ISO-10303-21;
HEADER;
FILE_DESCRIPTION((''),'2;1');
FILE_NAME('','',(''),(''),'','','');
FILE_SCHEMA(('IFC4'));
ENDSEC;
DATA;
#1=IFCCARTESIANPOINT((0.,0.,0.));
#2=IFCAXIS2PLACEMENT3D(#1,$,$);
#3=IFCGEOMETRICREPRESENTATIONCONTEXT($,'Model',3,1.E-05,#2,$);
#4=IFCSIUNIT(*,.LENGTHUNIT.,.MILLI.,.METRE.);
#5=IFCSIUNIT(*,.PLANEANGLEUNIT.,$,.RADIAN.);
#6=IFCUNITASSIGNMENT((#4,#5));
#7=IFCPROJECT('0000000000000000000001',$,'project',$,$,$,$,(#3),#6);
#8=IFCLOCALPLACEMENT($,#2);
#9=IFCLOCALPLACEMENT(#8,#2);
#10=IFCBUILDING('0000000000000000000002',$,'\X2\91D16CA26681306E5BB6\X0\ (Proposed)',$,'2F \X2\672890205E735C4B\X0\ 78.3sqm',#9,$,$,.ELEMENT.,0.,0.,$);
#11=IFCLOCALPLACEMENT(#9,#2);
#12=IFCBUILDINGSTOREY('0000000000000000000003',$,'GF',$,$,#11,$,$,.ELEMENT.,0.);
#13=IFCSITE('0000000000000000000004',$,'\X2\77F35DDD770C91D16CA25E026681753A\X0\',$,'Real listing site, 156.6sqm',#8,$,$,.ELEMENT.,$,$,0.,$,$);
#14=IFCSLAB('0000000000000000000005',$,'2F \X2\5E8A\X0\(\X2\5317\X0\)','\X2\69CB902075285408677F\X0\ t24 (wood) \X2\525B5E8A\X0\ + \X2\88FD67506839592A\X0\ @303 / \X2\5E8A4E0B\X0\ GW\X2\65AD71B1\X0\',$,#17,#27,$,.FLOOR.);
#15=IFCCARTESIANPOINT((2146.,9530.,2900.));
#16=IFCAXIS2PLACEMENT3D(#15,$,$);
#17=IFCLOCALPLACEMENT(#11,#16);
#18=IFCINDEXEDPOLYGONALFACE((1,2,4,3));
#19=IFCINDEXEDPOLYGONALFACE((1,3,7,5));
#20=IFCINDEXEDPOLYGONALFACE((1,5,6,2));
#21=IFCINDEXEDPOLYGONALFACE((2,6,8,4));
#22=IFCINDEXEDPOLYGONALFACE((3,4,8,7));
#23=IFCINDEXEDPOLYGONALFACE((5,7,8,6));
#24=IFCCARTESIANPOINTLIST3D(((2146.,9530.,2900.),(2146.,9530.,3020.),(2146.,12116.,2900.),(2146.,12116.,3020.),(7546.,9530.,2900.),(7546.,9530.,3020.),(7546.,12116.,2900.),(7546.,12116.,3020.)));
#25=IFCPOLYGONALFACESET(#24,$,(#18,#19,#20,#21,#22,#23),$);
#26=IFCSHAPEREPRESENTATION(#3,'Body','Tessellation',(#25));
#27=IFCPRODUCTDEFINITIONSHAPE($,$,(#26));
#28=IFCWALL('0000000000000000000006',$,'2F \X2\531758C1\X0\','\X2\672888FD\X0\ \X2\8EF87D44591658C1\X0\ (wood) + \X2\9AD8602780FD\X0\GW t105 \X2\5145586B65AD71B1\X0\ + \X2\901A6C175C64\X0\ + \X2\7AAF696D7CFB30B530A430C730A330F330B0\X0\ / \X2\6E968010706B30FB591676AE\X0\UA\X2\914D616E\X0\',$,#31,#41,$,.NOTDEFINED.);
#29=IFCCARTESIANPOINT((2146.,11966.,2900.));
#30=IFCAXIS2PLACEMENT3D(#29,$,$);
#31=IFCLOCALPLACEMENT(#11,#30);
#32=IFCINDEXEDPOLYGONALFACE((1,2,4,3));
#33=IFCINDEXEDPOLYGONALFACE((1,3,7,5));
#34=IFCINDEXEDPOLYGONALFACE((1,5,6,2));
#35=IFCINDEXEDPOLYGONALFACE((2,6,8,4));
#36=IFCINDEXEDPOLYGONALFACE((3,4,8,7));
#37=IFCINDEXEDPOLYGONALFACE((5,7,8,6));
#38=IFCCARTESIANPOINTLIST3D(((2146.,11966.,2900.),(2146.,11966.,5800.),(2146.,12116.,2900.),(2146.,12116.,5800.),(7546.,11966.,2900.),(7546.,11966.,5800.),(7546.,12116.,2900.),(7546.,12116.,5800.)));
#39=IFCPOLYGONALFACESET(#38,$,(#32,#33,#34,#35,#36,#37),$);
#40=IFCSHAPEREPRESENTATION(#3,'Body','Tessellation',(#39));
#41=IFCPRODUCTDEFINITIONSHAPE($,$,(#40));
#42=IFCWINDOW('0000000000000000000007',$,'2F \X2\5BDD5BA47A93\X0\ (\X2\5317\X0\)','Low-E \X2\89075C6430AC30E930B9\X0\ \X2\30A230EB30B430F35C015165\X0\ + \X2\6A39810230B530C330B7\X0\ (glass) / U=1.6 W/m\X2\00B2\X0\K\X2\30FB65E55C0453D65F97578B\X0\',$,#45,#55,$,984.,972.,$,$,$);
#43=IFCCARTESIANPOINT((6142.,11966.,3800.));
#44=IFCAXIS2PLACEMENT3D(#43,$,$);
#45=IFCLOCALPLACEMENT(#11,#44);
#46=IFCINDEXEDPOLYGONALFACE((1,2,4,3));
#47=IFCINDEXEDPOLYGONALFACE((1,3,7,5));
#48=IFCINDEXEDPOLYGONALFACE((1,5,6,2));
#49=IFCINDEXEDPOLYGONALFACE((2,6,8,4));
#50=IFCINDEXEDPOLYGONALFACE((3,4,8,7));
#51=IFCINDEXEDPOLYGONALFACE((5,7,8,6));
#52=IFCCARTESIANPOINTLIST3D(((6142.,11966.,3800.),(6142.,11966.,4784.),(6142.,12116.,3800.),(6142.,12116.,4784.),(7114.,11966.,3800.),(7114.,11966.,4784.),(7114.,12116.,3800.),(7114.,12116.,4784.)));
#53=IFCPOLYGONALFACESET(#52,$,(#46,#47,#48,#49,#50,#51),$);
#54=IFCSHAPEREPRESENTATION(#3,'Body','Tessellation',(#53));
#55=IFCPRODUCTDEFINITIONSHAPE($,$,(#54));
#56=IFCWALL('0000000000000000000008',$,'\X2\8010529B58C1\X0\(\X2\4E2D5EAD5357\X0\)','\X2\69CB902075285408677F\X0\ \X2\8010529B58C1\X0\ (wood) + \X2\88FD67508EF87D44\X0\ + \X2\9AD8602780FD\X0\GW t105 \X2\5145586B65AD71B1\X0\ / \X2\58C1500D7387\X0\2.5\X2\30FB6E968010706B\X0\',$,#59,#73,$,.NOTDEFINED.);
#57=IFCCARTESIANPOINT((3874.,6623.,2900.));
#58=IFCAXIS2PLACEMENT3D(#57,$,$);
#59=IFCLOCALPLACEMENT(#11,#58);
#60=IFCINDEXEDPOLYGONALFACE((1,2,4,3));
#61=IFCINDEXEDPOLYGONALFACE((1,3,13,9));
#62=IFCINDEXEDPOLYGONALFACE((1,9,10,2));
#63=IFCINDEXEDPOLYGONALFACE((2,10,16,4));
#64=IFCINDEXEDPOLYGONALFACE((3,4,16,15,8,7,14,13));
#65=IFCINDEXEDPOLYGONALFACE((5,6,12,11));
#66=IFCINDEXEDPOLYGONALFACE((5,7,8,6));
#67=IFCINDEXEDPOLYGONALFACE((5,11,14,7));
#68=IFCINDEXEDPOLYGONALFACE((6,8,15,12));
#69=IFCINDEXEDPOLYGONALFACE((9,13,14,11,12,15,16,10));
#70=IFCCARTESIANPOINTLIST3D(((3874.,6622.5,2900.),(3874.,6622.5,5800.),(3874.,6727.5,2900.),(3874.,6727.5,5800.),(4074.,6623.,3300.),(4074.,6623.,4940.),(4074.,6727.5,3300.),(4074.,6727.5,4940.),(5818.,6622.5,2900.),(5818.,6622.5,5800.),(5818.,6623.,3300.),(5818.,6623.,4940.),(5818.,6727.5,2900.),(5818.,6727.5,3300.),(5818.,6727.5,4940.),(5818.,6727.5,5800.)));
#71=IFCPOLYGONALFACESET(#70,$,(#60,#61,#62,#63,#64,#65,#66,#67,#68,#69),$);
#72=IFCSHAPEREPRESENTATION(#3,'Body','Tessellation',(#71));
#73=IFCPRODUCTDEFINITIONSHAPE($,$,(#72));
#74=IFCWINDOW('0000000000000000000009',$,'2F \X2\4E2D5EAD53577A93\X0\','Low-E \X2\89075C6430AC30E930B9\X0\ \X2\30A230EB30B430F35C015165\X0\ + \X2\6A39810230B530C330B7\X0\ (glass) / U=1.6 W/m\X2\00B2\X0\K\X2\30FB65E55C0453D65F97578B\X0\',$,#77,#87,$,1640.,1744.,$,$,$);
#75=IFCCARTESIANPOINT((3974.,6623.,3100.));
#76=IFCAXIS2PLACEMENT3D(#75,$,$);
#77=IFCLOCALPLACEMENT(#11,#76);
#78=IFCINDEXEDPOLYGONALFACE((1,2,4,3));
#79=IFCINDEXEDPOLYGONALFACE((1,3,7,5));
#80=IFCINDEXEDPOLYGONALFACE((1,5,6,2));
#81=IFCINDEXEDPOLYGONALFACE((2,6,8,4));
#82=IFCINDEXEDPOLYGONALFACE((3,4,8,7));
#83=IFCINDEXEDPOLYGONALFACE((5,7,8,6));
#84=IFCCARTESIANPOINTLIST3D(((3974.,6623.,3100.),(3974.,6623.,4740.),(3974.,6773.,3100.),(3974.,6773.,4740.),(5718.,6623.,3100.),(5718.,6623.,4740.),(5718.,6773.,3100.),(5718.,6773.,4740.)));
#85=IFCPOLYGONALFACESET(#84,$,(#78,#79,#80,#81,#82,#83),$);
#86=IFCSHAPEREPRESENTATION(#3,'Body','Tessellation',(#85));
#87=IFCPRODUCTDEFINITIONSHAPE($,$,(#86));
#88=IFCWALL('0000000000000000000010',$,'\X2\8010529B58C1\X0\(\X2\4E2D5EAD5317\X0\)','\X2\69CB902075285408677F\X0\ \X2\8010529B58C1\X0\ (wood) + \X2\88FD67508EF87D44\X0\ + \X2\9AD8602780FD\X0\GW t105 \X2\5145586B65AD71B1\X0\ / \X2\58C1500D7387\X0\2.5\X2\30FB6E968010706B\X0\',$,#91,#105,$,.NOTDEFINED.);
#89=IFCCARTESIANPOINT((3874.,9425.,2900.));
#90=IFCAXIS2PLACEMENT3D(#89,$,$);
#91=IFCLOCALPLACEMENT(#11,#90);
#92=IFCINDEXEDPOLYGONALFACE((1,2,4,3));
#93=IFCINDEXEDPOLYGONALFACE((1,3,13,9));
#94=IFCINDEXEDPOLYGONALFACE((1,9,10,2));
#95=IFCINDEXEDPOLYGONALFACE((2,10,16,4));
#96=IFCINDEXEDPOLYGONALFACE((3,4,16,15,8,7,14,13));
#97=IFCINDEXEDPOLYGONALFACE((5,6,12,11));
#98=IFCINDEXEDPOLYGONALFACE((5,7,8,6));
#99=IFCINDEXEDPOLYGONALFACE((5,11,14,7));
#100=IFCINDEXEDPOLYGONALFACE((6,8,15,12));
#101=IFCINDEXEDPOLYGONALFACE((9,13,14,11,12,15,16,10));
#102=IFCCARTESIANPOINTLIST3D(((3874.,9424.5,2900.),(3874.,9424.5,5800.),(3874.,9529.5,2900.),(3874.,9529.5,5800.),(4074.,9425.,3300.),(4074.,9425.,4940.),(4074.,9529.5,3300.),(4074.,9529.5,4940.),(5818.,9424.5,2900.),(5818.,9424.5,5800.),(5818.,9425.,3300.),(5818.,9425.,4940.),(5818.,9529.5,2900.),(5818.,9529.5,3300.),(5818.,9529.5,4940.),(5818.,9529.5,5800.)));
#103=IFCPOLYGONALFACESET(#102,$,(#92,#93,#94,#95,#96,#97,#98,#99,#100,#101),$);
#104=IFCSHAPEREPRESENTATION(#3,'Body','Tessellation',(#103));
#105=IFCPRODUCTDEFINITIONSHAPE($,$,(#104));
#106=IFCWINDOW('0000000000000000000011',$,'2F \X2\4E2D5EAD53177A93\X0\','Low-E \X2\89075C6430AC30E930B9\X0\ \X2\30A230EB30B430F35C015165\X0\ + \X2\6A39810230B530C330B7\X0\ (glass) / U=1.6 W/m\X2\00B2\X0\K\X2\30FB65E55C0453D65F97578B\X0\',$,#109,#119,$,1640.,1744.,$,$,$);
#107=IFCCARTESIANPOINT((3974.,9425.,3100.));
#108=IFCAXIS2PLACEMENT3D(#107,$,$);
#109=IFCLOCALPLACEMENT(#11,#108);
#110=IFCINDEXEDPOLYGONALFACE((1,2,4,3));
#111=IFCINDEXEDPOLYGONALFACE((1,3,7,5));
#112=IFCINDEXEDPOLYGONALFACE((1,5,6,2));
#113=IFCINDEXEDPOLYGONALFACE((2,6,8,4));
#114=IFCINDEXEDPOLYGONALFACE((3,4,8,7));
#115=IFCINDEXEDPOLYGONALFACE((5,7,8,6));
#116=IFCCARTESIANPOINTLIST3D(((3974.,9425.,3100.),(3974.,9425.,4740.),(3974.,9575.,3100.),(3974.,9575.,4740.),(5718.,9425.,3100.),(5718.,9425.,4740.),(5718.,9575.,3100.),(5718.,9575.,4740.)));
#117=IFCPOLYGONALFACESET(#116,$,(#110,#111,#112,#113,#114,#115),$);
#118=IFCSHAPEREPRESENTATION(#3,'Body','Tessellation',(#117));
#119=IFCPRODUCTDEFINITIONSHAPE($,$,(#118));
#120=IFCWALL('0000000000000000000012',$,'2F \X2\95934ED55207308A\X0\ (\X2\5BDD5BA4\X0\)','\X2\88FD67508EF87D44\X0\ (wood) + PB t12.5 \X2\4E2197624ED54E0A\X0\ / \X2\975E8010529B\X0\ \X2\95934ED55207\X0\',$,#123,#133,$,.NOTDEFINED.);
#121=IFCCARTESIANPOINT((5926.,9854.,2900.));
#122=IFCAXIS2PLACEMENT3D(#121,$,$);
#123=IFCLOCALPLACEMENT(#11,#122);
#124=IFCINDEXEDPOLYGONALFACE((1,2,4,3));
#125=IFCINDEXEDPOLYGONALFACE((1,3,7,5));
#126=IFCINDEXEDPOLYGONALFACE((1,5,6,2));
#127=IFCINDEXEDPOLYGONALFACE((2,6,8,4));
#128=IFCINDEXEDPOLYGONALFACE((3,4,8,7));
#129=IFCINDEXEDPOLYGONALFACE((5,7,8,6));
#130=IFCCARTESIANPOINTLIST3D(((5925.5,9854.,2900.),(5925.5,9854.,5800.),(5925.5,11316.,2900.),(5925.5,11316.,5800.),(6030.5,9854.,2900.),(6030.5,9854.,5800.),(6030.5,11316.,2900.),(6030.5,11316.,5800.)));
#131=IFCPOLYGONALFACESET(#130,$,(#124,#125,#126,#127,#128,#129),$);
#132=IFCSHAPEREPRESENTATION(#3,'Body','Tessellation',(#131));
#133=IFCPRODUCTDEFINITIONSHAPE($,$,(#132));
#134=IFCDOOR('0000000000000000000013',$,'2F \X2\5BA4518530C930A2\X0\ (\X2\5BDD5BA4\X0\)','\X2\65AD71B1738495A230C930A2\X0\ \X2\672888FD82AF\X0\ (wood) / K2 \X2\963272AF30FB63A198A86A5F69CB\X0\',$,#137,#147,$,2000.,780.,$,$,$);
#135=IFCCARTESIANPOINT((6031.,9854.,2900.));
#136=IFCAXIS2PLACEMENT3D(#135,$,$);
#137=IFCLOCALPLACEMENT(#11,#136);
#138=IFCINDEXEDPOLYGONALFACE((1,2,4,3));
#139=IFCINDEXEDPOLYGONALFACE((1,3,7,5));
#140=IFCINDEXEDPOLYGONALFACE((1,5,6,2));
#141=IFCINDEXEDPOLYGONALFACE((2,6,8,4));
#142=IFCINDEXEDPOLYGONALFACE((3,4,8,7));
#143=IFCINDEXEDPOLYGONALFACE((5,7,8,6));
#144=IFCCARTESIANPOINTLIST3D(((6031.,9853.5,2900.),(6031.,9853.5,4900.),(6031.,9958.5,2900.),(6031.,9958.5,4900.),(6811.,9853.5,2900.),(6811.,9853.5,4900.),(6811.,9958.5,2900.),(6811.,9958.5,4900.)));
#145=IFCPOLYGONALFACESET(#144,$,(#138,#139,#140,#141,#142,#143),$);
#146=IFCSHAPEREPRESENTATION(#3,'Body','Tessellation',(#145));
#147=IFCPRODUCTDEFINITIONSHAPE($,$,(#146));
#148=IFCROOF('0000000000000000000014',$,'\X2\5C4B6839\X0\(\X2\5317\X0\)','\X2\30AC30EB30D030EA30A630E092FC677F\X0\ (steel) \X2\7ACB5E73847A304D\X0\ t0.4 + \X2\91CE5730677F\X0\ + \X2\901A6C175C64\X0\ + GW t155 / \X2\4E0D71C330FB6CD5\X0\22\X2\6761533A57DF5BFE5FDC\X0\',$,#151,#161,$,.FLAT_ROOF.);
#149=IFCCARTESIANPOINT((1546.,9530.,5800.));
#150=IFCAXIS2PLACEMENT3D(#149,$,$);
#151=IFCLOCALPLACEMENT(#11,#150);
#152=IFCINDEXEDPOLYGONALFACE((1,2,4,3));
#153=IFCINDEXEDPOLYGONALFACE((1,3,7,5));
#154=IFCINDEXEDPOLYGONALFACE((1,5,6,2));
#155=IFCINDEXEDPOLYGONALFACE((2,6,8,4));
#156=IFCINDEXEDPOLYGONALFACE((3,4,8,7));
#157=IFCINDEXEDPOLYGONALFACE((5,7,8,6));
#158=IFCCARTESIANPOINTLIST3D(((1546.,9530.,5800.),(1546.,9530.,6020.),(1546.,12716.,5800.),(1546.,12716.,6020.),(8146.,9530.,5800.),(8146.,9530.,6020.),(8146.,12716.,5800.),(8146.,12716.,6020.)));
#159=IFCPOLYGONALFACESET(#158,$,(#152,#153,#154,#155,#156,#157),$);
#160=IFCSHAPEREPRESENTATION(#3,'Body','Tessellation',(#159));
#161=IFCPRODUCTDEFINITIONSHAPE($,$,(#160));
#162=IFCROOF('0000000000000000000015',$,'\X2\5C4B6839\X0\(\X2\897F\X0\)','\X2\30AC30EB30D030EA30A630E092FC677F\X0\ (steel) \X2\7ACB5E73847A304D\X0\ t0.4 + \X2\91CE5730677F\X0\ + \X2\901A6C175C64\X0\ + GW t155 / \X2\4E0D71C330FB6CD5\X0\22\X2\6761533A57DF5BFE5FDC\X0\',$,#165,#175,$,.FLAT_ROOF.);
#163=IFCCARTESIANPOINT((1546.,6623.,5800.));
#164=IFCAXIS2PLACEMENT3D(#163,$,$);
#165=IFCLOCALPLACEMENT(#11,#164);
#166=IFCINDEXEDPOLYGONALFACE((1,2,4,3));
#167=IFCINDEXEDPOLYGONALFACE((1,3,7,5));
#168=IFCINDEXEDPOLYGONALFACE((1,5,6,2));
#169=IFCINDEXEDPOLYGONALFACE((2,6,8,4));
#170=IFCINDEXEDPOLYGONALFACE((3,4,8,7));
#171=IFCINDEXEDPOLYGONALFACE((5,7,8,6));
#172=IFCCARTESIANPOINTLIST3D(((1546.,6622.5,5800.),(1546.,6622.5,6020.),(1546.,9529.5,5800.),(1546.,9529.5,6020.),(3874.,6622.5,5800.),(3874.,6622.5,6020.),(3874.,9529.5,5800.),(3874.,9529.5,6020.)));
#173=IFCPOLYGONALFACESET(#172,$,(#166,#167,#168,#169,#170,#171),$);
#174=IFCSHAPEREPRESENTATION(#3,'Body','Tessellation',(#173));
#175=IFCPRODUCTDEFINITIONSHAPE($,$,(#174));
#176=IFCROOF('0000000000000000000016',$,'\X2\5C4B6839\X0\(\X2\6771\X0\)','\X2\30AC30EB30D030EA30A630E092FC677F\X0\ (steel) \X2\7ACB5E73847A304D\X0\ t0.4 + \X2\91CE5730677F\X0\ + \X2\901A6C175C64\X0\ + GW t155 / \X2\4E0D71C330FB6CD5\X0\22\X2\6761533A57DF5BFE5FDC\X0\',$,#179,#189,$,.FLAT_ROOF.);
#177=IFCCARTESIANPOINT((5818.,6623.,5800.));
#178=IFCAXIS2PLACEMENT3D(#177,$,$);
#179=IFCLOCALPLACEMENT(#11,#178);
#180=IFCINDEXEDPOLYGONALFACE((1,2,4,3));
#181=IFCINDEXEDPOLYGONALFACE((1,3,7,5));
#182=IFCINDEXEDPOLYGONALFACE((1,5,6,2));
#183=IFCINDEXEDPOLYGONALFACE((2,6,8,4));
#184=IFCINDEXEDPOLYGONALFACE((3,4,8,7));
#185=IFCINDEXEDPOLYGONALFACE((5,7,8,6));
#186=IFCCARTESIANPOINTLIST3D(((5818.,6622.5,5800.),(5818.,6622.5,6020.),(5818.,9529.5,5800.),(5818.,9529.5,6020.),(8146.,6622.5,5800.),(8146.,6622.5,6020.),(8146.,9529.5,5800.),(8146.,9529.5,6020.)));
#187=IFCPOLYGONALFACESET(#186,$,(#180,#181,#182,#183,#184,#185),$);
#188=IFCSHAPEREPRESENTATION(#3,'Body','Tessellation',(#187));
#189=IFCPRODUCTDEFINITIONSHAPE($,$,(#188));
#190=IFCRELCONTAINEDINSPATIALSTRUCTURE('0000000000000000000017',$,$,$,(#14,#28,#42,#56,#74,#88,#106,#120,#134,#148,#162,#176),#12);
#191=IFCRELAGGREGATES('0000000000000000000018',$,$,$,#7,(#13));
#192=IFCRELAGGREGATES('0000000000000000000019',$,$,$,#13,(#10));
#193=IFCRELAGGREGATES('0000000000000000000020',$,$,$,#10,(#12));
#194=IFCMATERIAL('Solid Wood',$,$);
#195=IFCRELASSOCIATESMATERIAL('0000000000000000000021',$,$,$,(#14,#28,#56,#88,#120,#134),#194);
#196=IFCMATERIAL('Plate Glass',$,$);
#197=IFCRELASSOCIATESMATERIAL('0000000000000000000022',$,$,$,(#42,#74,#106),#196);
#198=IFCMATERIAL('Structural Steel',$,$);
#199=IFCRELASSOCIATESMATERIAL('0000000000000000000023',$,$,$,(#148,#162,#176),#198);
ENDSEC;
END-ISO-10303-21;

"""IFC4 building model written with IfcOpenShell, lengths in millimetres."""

from ifc_helpers import new_model, si_unit, frame, frame_2d, origin, place, context, project, spatial, rectangle, extrude, material, element, fill, save


model = new_model("IFC4")

# Units and contexts
model_context = context("Model", 3, precision=1e-05, world=origin())
ifc_project = project(units=[si_unit("LENGTHUNIT", "METRE", prefix="MILLI"), si_unit("PLANEANGLEUNIT", "RADIAN")], contexts=[model_context])

# Site, building, storey
site_placement = place(None, origin())
site = spatial("IfcSite", under=ifc_project, at=site_placement, Name="石川県金沢市暁町", ObjectType="Real listing site, 156.6sqm", CompositionType="ELEMENT", RefElevation=0.0)
building_placement = place(site_placement, origin())
building = spatial("IfcBuilding", under=site, at=building_placement, Name="金沢暁の家 (Proposed)", ObjectType="2F 木造平屋 78.3sqm", CompositionType="ELEMENT", ElevationOfRefHeight=0.0, ElevationOfTerrain=0.0)
storey_placement = place(building_placement, origin())
storey = spatial("IfcBuildingStorey", under=building, at=storey_placement, Name="GF", CompositionType="ELEMENT", Elevation=0.0)

# Slab
ifc_material_1 = material(Name="Solid Wood")
slab_placement = place(storey_placement, frame((2146.0, 9530.0, 2900.0)))
element("IfcSlab", 1, at=slab_placement, inside=storey, material=ifc_material_1, Name="2F 床(北)", Description="構造用合板 t24 (wood) 剛床 + 製材根太 @303 / 床下 GW断熱", PredefinedType="FLOOR", context=model_context, shape_type="SweptSolid", body=[
    extrude(rectangle(XDim=5400.0, YDim=2586.0, at=frame_2d((2700.0, 1293.0))), frame((2146.0, 9530.0, 2900.0)), (0.0, 0.0, 1.0), 120.0),
])

# Walls, openings, windows
wall_1_placement = place(storey_placement, frame((2146.0, 11966.0, 2900.0)))
wall_1 = element("IfcWall", 2, at=wall_1_placement, inside=storey, material=ifc_material_1, Name="2F 北壁", Description="木製 軸組外壁 (wood) + 高性能GW t105 充填断熱 + 通気層 + 窯業系サイディング / 準耐火・外皮UA配慮", PredefinedType="NOTDEFINED", context=model_context, shape_type="SweptSolid", body=[
    extrude(rectangle(XDim=5400.0, YDim=150.0, at=frame_2d((2700.0, 75.0))), frame((2146.0, 11966.0, 2900.0)), (0.0, 0.0, 1.0), 2900.0),
])
opening_1_placement = place(storey_placement, frame((6142.0, 11966.0, 3800.0)))
opening_1 = element("IfcOpeningElement", 3, at=opening_1_placement, cuts=wall_1, PredefinedType="NOTDEFINED", context=model_context, shape_type="SweptSolid", body=[
    extrude(rectangle(XDim=972.0, YDim=150.0, at=frame_2d((486.0, 75.0))), frame((6142.0, 11966.0, 3800.0)), (0.0, 0.0, 1.0), 984.0),
])
ifc_material_2 = material(Name="Plate Glass")
window_1_placement = place(storey_placement, frame((6142.0, 11966.0, 3800.0)))
window_1 = element("IfcWindow", 4, at=window_1_placement, inside=storey, material=ifc_material_2, Name="2F 寝室窓 (北)", Description="Low-E 複層ガラス アルゴン封入 + 樹脂サッシ (glass) / U=1.6 W/m²K・日射取得型", OverallHeight=984.0, OverallWidth=972.0, context=model_context, shape_type="SweptSolid", body=[
    extrude(rectangle(XDim=972.0, YDim=150.0, at=frame_2d((486.0, 75.0))), frame((6142.0, 11966.0, 3800.0)), (0.0, 0.0, 1.0), 984.0),
])
fill(opening_1, window_1)
wall_2_placement = place(storey_placement, frame((3874.0, 6623.0, 2900.0)))
wall_2 = element("IfcWall", 5, at=wall_2_placement, inside=storey, material=ifc_material_1, Name="耐力壁(中庭南)", Description="構造用合板 耐力壁 (wood) + 製材軸組 + 高性能GW t105 充填断熱 / 壁倍率2.5・準耐火", PredefinedType="NOTDEFINED", context=model_context, shape_type="SweptSolid", body=[
    extrude(rectangle(XDim=1944.0, YDim=105.0, at=frame_2d((972.0, 52.0))), frame((3874.0, 6623.0, 2900.0)), (0.0, 0.0, 1.0), 2900.0),
])
opening_2_placement = place(storey_placement, frame((3974.0, 6623.0, 3100.0)))
opening_2 = element("IfcOpeningElement", 6, at=opening_2_placement, cuts=wall_2, PredefinedType="NOTDEFINED", context=model_context, shape_type="SweptSolid", body=[
    extrude(rectangle(XDim=1744.0, YDim=150.0, at=frame_2d((872.0, 75.0))), frame((3974.0, 6623.0, 3100.0)), (0.0, 0.0, 1.0), 1640.0),
])
window_2_placement = place(storey_placement, frame((3974.0, 6623.0, 3100.0)))
window_2 = element("IfcWindow", 7, at=window_2_placement, inside=storey, material=ifc_material_2, Name="2F 中庭南窓", Description="Low-E 複層ガラス アルゴン封入 + 樹脂サッシ (glass) / U=1.6 W/m²K・日射取得型", OverallHeight=1640.0, OverallWidth=1744.0, context=model_context, shape_type="SweptSolid", body=[
    extrude(rectangle(XDim=1744.0, YDim=150.0, at=frame_2d((872.0, 75.0))), frame((3974.0, 6623.0, 3100.0)), (0.0, 0.0, 1.0), 1640.0),
])
fill(opening_2, window_2)
wall_3_placement = place(storey_placement, frame((3874.0, 9425.0, 2900.0)))
wall_3 = element("IfcWall", 8, at=wall_3_placement, inside=storey, material=ifc_material_1, Name="耐力壁(中庭北)", Description="構造用合板 耐力壁 (wood) + 製材軸組 + 高性能GW t105 充填断熱 / 壁倍率2.5・準耐火", PredefinedType="NOTDEFINED", context=model_context, shape_type="SweptSolid", body=[
    extrude(rectangle(XDim=1944.0, YDim=105.0, at=frame_2d((972.0, 52.0))), frame((3874.0, 9425.0, 2900.0)), (0.0, 0.0, 1.0), 2900.0),
])
opening_3_placement = place(storey_placement, frame((3974.0, 9425.0, 3100.0)))
opening_3 = element("IfcOpeningElement", 9, at=opening_3_placement, cuts=wall_3, PredefinedType="NOTDEFINED", context=model_context, shape_type="SweptSolid", body=[
    extrude(rectangle(XDim=1744.0, YDim=150.0, at=frame_2d((872.0, 75.0))), frame((3974.0, 9425.0, 3100.0)), (0.0, 0.0, 1.0), 1640.0),
])
window_3_placement = place(storey_placement, frame((3974.0, 9425.0, 3100.0)))
window_3 = element("IfcWindow", 10, at=window_3_placement, inside=storey, material=ifc_material_2, Name="2F 中庭北窓", Description="Low-E 複層ガラス アルゴン封入 + 樹脂サッシ (glass) / U=1.6 W/m²K・日射取得型", OverallHeight=1640.0, OverallWidth=1744.0, context=model_context, shape_type="SweptSolid", body=[
    extrude(rectangle(XDim=1744.0, YDim=150.0, at=frame_2d((872.0, 75.0))), frame((3974.0, 9425.0, 3100.0)), (0.0, 0.0, 1.0), 1640.0),
])
fill(opening_3, window_3)

# Wall
wall_4_placement = place(storey_placement, frame((5926.0, 9854.0, 2900.0)))
element("IfcWall", 11, at=wall_4_placement, inside=storey, material=ifc_material_1, Name="2F 間仕切り (寝室)", Description="製材軸組 (wood) + PB t12.5 両面仕上 / 非耐力 間仕切", PredefinedType="NOTDEFINED", context=model_context, shape_type="SweptSolid", body=[
    extrude(rectangle(XDim=105.0, YDim=1462.0, at=frame_2d((52.0, 731.0))), frame((5926.0, 9854.0, 2900.0)), (0.0, 0.0, 1.0), 2900.0),
])

# Door
door_placement = place(storey_placement, frame((6031.0, 9854.0, 2900.0)))
element("IfcDoor", 12, at=door_placement, inside=storey, material=ifc_material_1, Name="2F 室内ドア (寝室)", Description="断熱玄関ドア 木製芯 (wood) / K2 防犯・採風機構", OverallHeight=2000.0, OverallWidth=780.0, context=model_context, shape_type="SweptSolid", body=[
    extrude(rectangle(XDim=780.0, YDim=105.0, at=frame_2d((390.0, 52.0))), frame((6031.0, 9854.0, 2900.0)), (0.0, 0.0, 1.0), 2000.0),
])

# Roofs
ifc_material_3 = material(Name="Structural Steel")
for number, where, name in (
    (13, (1546.0, 9530.0, 5800.0), "屋根(北)"),
):
    element("IfcRoof", number, at=place(storey_placement, frame(where)), inside=storey, material=ifc_material_3, Name=name, Description="ガルバリウム鋼板 (steel) 立平葺き t0.4 + 野地板 + 通気層 + GW t155 / 不燃・法22条区域対応", PredefinedType="FLAT_ROOF", context=model_context, shape_type="SweptSolid", body=[
        extrude(rectangle(XDim=6600.0, YDim=3186.0, at=frame_2d((3300.0, 1593.0))), frame((1546.0, 9530.0, 5800.0)), (0.0, 0.0, 1.0), 220.0),
    ])
roof_1_placement = place(storey_placement, frame((1546.0, 6623.0, 5800.0)))
element("IfcRoof", 14, at=roof_1_placement, inside=storey, material=ifc_material_3, Name="屋根(西)", Description="ガルバリウム鋼板 (steel) 立平葺き t0.4 + 野地板 + 通気層 + GW t155 / 不燃・法22条区域対応", PredefinedType="FLAT_ROOF", context=model_context, shape_type="SweptSolid", body=[
    extrude(rectangle(XDim=2328.0, YDim=2907.0, at=frame_2d((1164.0, 1453.0))), frame((1546.0, 6623.0, 5800.0)), (0.0, 0.0, 1.0), 220.0),
])
roof_2_placement = place(storey_placement, frame((5818.0, 6623.0, 5800.0)))
element("IfcRoof", 15, at=roof_2_placement, inside=storey, material=ifc_material_3, Name="屋根(東)", Description="ガルバリウム鋼板 (steel) 立平葺き t0.4 + 野地板 + 通気層 + GW t155 / 不燃・法22条区域対応", PredefinedType="FLAT_ROOF", context=model_context, shape_type="SweptSolid", body=[
    extrude(rectangle(XDim=2328.0, YDim=2907.0, at=frame_2d((1164.0, 1453.0))), frame((5818.0, 6623.0, 5800.0)), (0.0, 0.0, 1.0), 220.0),
])

save(model, "model.ifc")
